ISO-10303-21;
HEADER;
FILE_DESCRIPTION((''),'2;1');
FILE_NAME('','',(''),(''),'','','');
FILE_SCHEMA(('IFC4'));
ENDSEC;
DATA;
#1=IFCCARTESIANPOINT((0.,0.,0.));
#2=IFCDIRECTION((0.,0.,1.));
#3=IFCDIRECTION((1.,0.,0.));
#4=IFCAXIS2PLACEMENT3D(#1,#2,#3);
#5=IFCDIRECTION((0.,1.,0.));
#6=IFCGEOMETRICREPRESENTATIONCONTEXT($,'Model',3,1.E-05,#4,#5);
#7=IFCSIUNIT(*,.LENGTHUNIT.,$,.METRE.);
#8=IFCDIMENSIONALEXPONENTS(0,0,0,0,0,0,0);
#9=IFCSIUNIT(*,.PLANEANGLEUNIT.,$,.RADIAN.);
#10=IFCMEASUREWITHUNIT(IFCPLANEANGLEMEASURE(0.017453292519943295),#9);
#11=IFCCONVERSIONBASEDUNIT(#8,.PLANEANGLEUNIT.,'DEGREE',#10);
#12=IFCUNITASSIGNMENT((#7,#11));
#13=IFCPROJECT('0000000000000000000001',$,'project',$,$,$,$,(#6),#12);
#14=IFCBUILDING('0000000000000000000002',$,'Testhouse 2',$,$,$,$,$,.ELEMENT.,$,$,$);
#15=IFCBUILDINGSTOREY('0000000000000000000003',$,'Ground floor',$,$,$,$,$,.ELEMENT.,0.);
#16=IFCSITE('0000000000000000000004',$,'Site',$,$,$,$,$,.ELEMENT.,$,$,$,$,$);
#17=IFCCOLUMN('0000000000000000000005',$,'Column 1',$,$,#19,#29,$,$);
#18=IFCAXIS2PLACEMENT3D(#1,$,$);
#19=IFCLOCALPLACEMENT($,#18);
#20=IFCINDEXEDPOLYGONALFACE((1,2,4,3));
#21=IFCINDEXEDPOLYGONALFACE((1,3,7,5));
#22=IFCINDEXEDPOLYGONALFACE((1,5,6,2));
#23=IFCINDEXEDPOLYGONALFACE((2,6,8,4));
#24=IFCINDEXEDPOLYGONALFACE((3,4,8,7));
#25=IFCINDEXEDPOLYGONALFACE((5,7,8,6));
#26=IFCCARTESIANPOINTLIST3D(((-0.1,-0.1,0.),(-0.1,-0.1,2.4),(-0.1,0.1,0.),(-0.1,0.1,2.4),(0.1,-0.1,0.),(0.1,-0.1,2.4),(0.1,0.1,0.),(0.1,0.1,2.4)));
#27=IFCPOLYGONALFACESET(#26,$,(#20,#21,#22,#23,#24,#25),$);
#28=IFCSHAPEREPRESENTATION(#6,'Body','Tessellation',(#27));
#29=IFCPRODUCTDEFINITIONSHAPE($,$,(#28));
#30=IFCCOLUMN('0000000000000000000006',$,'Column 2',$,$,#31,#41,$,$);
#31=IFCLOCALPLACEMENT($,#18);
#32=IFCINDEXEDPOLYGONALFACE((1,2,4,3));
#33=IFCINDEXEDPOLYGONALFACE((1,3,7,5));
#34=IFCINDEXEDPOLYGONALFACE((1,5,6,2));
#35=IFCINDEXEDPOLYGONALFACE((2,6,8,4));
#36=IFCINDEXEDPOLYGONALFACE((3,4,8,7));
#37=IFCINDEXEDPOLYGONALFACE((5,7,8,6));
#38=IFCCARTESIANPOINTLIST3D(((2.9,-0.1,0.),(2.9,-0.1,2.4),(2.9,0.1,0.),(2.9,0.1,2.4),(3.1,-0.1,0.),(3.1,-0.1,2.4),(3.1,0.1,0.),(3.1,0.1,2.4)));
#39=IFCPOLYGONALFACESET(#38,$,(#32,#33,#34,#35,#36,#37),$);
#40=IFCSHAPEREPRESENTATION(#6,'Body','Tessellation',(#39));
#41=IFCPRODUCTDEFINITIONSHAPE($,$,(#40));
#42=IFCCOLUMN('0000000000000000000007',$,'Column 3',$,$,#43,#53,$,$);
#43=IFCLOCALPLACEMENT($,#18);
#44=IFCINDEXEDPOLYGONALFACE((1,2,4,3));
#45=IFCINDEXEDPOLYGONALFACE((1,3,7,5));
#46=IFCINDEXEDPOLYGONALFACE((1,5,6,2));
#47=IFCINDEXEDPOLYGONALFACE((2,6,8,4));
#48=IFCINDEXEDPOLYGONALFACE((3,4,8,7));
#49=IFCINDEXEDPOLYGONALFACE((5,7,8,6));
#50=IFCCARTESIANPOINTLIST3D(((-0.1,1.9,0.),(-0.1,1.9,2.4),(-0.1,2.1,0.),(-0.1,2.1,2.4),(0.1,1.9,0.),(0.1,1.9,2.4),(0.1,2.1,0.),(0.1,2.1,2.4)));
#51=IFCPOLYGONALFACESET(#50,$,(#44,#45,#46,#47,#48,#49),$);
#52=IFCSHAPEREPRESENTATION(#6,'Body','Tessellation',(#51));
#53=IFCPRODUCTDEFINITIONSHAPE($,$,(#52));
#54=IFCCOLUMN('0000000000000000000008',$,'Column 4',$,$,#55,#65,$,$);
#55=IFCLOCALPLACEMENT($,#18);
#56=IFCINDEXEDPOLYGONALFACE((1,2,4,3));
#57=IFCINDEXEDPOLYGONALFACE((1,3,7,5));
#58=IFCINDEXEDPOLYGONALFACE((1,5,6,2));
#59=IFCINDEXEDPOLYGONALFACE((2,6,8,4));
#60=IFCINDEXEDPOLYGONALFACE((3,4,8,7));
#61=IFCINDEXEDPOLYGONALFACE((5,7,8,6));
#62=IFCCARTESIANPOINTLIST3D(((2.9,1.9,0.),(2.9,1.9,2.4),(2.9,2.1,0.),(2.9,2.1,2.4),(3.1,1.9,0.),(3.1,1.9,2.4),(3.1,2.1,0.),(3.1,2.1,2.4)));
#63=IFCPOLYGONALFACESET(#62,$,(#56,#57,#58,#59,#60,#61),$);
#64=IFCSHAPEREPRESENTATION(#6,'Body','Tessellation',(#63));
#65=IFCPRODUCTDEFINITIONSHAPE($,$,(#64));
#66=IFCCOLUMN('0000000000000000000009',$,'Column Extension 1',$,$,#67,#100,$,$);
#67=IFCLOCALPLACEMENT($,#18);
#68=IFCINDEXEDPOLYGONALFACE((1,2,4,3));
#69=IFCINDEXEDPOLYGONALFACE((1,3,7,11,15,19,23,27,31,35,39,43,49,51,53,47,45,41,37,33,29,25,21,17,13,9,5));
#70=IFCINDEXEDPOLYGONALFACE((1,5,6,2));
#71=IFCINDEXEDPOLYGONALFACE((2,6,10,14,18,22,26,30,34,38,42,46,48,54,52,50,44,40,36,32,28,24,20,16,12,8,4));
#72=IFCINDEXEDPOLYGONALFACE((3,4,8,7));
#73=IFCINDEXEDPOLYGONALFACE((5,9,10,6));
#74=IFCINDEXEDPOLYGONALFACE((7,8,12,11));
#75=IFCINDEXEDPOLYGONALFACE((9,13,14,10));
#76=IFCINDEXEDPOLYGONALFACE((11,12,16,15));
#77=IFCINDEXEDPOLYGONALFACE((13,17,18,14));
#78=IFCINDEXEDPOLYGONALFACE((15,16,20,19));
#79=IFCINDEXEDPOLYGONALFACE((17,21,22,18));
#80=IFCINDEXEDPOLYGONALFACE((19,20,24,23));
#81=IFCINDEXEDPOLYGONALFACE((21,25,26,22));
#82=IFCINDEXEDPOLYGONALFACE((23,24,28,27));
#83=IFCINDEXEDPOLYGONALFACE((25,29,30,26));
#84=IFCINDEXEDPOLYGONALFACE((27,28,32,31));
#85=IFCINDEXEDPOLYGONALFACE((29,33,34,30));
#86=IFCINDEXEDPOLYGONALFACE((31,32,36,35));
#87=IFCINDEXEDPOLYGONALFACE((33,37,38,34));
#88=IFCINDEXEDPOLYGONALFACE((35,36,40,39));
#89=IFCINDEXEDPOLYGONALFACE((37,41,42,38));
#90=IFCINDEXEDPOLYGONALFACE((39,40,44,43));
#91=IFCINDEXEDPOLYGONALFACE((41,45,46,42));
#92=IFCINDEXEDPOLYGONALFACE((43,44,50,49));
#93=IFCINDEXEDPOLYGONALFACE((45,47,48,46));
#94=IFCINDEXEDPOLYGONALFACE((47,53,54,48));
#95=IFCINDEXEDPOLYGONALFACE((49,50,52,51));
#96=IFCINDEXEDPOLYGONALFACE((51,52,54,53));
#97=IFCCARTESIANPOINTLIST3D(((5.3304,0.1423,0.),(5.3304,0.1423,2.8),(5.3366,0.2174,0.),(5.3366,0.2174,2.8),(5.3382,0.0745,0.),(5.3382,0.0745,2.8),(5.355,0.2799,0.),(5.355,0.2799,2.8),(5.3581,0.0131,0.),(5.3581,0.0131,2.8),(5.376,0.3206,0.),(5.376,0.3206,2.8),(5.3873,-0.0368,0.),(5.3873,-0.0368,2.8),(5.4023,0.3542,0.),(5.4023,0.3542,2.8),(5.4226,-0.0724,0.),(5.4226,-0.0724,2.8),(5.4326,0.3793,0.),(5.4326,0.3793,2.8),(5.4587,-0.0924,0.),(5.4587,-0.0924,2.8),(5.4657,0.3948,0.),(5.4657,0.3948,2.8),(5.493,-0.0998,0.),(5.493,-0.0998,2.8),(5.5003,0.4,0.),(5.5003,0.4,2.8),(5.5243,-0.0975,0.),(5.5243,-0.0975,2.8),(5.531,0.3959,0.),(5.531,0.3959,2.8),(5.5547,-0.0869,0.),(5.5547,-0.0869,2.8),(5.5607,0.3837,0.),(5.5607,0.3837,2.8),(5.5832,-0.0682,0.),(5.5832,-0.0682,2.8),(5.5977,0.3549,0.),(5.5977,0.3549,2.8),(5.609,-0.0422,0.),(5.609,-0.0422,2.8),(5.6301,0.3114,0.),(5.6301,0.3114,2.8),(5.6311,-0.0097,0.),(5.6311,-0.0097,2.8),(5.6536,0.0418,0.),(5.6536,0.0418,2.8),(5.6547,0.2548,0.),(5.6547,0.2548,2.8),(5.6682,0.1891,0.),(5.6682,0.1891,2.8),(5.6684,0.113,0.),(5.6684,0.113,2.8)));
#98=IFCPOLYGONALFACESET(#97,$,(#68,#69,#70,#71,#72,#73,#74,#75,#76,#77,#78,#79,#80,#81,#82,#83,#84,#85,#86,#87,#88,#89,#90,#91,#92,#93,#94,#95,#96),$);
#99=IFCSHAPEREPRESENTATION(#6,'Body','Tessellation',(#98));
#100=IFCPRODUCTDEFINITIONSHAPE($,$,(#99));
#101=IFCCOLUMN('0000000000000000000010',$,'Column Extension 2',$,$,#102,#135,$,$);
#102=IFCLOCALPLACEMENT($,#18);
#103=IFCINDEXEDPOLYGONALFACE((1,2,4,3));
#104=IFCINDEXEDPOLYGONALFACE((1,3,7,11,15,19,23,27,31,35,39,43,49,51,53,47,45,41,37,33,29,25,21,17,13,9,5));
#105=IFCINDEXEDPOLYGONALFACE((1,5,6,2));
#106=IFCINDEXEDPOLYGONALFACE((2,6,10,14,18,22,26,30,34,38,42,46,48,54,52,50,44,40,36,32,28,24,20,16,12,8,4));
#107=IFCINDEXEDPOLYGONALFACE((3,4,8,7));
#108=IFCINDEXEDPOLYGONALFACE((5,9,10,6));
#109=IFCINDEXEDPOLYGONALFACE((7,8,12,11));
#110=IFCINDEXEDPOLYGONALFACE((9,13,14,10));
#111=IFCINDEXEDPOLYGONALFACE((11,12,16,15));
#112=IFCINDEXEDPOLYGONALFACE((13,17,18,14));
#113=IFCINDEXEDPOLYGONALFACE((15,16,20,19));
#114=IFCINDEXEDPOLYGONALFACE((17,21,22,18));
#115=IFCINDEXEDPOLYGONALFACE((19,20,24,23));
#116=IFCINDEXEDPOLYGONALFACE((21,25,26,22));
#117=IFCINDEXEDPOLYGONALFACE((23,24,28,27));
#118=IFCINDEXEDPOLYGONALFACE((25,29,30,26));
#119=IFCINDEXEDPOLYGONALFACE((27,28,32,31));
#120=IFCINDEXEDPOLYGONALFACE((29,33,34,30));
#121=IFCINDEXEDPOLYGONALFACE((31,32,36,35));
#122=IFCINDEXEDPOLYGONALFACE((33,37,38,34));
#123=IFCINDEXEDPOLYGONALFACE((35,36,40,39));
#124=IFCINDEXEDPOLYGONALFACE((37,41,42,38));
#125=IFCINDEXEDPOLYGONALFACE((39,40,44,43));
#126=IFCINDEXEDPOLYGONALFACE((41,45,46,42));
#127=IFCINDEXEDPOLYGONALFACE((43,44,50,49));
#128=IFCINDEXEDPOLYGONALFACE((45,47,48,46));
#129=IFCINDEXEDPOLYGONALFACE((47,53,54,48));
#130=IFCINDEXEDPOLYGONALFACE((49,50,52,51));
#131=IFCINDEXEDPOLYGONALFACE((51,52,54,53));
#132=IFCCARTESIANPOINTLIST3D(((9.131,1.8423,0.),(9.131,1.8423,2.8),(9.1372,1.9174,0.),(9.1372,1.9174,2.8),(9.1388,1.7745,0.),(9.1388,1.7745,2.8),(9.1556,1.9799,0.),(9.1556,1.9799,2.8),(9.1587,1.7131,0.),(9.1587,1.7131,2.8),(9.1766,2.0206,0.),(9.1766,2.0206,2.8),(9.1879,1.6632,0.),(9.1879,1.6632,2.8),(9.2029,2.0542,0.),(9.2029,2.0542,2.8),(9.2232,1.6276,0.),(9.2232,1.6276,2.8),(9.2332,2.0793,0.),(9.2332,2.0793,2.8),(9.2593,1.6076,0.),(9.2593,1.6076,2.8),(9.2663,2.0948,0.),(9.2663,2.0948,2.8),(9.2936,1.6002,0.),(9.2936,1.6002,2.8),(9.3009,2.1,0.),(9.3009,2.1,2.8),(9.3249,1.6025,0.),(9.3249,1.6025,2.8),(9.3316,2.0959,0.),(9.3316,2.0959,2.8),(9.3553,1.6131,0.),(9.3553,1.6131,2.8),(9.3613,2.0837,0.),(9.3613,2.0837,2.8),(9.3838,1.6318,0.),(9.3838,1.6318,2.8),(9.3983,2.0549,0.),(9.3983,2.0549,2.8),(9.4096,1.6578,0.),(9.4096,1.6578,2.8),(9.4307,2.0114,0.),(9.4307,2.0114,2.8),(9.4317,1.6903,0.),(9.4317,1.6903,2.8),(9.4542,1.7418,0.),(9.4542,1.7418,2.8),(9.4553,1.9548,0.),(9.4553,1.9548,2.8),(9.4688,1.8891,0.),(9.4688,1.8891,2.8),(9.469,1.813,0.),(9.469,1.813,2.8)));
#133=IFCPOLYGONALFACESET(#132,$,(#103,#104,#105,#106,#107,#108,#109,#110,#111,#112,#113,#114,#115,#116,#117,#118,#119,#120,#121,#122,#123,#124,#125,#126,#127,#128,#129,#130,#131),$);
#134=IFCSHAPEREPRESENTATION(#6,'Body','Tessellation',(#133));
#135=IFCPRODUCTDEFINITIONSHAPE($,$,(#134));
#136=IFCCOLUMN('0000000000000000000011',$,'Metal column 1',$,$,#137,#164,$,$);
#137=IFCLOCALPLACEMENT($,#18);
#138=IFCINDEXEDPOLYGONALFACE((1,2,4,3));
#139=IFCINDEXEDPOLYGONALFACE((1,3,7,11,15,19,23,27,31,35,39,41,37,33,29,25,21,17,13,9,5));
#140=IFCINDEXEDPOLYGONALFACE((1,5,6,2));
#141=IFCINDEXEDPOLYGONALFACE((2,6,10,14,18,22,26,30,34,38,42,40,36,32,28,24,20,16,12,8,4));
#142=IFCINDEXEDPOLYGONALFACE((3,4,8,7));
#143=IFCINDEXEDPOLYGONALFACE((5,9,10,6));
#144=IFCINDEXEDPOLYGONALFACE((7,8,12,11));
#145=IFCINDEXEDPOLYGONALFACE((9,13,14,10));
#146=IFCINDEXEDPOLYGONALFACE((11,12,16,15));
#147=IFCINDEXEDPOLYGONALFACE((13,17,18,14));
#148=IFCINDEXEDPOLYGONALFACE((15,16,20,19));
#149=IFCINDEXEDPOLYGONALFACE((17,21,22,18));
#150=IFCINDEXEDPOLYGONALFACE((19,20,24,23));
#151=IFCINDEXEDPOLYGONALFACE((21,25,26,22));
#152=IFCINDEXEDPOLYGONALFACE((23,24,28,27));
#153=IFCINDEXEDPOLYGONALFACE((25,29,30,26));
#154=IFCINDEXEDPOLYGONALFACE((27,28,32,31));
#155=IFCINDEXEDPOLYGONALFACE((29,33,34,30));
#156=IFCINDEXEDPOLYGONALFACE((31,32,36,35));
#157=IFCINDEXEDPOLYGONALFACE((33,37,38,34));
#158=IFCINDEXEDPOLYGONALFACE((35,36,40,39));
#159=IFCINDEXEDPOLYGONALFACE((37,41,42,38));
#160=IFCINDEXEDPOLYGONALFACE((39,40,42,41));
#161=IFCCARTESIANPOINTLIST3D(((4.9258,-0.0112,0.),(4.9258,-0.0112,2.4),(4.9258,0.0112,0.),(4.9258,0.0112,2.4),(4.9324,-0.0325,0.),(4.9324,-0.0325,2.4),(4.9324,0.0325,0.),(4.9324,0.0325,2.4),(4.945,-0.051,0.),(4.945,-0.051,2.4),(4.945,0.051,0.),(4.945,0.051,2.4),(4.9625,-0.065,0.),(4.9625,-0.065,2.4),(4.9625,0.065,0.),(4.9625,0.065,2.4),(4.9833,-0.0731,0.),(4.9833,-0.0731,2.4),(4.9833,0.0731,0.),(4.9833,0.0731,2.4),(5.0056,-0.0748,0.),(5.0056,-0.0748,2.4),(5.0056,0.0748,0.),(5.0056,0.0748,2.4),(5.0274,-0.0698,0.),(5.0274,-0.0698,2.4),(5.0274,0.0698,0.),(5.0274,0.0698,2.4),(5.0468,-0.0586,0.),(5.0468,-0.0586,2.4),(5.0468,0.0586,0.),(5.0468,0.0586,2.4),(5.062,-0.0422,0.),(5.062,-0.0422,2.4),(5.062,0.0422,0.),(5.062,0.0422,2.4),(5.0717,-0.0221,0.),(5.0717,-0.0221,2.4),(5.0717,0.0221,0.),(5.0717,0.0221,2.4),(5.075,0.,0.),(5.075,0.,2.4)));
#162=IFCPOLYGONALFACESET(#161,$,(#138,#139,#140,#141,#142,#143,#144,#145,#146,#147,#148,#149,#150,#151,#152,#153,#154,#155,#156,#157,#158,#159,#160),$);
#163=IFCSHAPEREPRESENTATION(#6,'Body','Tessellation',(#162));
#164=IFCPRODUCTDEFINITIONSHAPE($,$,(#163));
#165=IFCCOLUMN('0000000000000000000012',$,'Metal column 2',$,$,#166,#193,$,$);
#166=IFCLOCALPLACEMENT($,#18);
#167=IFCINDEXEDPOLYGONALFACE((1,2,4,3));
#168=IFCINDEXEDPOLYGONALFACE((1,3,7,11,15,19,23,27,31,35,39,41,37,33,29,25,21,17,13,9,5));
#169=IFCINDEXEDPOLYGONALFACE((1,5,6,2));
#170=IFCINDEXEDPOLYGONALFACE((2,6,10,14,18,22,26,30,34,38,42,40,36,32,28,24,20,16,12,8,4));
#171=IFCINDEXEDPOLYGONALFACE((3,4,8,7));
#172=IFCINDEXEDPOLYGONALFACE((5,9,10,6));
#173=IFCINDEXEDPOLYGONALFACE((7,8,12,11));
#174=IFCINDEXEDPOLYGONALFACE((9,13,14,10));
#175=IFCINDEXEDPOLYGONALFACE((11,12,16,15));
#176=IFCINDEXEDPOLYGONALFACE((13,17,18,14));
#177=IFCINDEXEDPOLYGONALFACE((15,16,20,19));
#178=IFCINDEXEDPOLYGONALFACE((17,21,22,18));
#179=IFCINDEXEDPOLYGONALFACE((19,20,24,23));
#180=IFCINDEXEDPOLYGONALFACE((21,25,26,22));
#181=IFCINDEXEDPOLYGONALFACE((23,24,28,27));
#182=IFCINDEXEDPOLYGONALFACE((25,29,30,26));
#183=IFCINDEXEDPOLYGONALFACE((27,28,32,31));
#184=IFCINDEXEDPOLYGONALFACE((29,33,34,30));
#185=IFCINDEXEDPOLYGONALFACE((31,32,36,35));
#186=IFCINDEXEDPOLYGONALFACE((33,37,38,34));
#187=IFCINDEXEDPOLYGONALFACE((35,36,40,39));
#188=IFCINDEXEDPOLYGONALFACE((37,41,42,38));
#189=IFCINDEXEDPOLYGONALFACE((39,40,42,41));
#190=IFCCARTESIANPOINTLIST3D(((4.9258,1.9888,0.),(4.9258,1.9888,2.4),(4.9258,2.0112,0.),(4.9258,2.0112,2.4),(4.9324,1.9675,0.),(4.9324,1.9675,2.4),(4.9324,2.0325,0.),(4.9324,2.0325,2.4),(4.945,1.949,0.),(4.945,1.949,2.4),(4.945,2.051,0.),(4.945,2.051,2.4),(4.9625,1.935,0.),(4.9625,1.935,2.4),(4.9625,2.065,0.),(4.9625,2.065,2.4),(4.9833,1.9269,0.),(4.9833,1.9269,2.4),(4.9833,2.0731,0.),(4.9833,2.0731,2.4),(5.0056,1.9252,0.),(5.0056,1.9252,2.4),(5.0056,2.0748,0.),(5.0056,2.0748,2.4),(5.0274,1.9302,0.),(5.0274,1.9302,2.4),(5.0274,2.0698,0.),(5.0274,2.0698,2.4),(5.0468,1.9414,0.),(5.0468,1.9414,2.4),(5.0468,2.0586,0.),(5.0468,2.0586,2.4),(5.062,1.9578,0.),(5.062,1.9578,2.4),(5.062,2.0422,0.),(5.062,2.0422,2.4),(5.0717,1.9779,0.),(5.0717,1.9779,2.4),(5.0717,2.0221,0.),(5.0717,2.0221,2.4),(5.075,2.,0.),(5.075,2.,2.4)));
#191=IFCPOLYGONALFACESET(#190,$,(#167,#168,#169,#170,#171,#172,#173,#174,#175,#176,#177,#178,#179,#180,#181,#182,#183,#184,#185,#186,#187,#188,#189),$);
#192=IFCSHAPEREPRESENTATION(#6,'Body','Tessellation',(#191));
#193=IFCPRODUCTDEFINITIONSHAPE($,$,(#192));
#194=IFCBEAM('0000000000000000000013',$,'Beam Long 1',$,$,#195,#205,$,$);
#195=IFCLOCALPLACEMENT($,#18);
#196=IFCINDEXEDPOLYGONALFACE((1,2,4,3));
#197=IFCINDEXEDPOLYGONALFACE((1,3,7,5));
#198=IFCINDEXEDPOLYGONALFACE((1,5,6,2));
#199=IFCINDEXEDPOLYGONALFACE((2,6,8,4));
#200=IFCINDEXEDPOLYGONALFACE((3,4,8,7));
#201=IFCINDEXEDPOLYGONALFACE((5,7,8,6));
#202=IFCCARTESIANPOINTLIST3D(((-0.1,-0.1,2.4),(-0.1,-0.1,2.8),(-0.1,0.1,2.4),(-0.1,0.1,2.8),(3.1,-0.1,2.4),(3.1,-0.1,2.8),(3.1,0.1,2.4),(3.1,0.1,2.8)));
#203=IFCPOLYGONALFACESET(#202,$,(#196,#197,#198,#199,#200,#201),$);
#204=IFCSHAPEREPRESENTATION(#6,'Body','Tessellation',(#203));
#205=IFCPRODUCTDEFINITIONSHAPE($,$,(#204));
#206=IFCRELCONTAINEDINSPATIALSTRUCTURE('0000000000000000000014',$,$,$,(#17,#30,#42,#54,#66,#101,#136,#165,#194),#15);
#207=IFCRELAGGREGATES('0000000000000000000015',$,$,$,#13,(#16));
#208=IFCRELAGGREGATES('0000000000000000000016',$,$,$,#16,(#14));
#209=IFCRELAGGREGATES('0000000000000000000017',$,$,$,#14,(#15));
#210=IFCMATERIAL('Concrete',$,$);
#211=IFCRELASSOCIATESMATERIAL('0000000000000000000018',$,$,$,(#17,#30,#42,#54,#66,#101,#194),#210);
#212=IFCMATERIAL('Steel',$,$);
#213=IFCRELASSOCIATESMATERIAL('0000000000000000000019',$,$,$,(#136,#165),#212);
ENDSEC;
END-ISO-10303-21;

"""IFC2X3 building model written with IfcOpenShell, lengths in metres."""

from ifc_helpers import new_model, entity, si_unit, converted_unit, direction, frame, origin_with_axes, origin_2d_with_axis, place, context, project, spatial, polyline, circle, ellipse, outline, extrude, material, element, save


model = new_model("IFC2X3")

# Units and contexts
model_context = context("Model", 3, precision=1e-05, world=origin_with_axes(), true_north=direction((0.0, 1.0, 0.0)))
ifc_project = project(units=[si_unit("LENGTHUNIT", "METRE"), converted_unit("PLANEANGLEUNIT", "DEGREE", entity("IfcPlaneAngleMeasure", 0.017453292519943295), si_unit("PLANEANGLEUNIT", "RADIAN"), dimensions=[0, 0, 0, 0, 0, 0, 0])], contexts=[model_context])

# Site, building, storey
site = spatial("IfcSite", under=ifc_project, Name="Site", CompositionType="ELEMENT")
building = spatial("IfcBuilding", under=site, Name="Testhouse 2", CompositionType="ELEMENT")
storey = spatial("IfcBuildingStorey", under=building, Name="Ground floor", CompositionType="ELEMENT", Elevation=0.0)

# Columns
ifc_material_1 = material(Name="Concrete")
column_1_placement = place(None, origin_with_axes())
element("IfcColumn", 1, at=column_1_placement, inside=storey, material=ifc_material_1, Name="Column 1", context=model_context, shape_type="SweptSolid", body=[
    extrude(outline(polyline([(-0.1, -0.1), (0.1, -0.1), (0.1, 0.1), (-0.1, 0.1), (-0.1, -0.1)])), origin_with_axes(), (0.0, 0.0, 1.0), 2.4),
])
column_2_placement = place(None, origin_with_axes())
element("IfcColumn", 2, at=column_2_placement, inside=storey, material=ifc_material_1, Name="Column 2", context=model_context, shape_type="SweptSolid", body=[
    extrude(outline(polyline([(-0.1, -0.1), (0.1, -0.1), (0.1, 0.1), (-0.1, 0.1), (-0.1, -0.1)])), frame((3.0, 0.0, 0.0), z_axis=(0.0, 0.0, 1.0), x_axis=(1.0, 0.0, 0.0)), (0.0, 0.0, 1.0), 2.4),
])
column_3_placement = place(None, origin_with_axes())
element("IfcColumn", 3, at=column_3_placement, inside=storey, material=ifc_material_1, Name="Column 3", context=model_context, shape_type="SweptSolid", body=[
    extrude(outline(polyline([(-0.1, -0.1), (0.1, -0.1), (0.1, 0.1), (-0.1, 0.1), (-0.1, -0.1)])), frame((0.0, 2.0, 0.0), z_axis=(0.0, 0.0, 1.0), x_axis=(1.0, 0.0, 0.0)), (0.0, 0.0, 1.0), 2.4),
])
column_4_placement = place(None, origin_with_axes())
element("IfcColumn", 4, at=column_4_placement, inside=storey, material=ifc_material_1, Name="Column 4", context=model_context, shape_type="SweptSolid", body=[
    extrude(outline(polyline([(-0.1, -0.1), (0.1, -0.1), (0.1, 0.1), (-0.1, 0.1), (-0.1, -0.1)])), frame((3.0, 2.0, 0.0), z_axis=(0.0, 0.0, 1.0), x_axis=(1.0, 0.0, 0.0)), (0.0, 0.0, 1.0), 2.4),
])
column_5_placement = place(None, origin_with_axes())
element("IfcColumn", 5, at=column_5_placement, inside=storey, material=ifc_material_1, Name="Column Extension 1", context=model_context, shape_type="SweptSolid", body=[
    extrude(ellipse(SemiAxis1=0.25, SemiAxis2=0.17, at=origin_2d_with_axis()), frame((5.5003, 0.15, 0.0), z_axis=(0.0, 0.0, 1.0), x_axis=(0.0, 1.0, 0.0)), (0.0, 0.0, 1.0), 2.8),
])
column_6_placement = place(None, origin_with_axes())
element("IfcColumn", 6, at=column_6_placement, inside=storey, material=ifc_material_1, Name="Column Extension 2", context=model_context, shape_type="SweptSolid", body=[
    extrude(ellipse(SemiAxis1=0.25, SemiAxis2=0.17, at=origin_2d_with_axis()), frame((9.3009, 1.85, 0.0), z_axis=(0.0, 0.0, 1.0), x_axis=(0.0, 1.0, 0.0)), (0.0, 0.0, 1.0), 2.8),
])
ifc_material_2 = material(Name="Steel")
column_7_placement = place(None, origin_with_axes())
element("IfcColumn", 7, at=column_7_placement, inside=storey, material=ifc_material_2, Name="Metal column 1", context=model_context, shape_type="SweptSolid", body=[
    extrude(circle(Radius=0.075, at=origin_2d_with_axis()), frame((5.0, 0.0, 0.0), z_axis=(0.0, 0.0, 1.0), x_axis=(1.0, 0.0, 0.0)), (0.0, 0.0, 1.0), 2.4),
])
column_8_placement = place(None, origin_with_axes())
element("IfcColumn", 8, at=column_8_placement, inside=storey, material=ifc_material_2, Name="Metal column 2", context=model_context, shape_type="SweptSolid", body=[
    extrude(circle(Radius=0.075, at=origin_2d_with_axis()), frame((5.0, 2.0, 0.0), z_axis=(0.0, 0.0, 1.0), x_axis=(1.0, 0.0, 0.0)), (0.0, 0.0, 1.0), 2.4),
])

# Beam
beam_1_placement = place(None, origin_with_axes())
element("IfcBeam", 9, at=beam_1_placement, inside=storey, material=ifc_material_1, Name="Beam Long 1", context=model_context, shape_type="SweptSolid", body=[
    extrude(outline(polyline([(-0.2, -0.1), (0.2, -0.1), (0.2, 0.1), (-0.2, 0.1), (-0.2, -0.1)])), frame((-0.1, 0.0, 2.6), z_axis=(1.0, 0.0, 0.0), x_axis=(0.0, 0.0, -1.0)), (0.0, 0.0, 1.0), 3.2),
])

save(model, "model.ifc")
